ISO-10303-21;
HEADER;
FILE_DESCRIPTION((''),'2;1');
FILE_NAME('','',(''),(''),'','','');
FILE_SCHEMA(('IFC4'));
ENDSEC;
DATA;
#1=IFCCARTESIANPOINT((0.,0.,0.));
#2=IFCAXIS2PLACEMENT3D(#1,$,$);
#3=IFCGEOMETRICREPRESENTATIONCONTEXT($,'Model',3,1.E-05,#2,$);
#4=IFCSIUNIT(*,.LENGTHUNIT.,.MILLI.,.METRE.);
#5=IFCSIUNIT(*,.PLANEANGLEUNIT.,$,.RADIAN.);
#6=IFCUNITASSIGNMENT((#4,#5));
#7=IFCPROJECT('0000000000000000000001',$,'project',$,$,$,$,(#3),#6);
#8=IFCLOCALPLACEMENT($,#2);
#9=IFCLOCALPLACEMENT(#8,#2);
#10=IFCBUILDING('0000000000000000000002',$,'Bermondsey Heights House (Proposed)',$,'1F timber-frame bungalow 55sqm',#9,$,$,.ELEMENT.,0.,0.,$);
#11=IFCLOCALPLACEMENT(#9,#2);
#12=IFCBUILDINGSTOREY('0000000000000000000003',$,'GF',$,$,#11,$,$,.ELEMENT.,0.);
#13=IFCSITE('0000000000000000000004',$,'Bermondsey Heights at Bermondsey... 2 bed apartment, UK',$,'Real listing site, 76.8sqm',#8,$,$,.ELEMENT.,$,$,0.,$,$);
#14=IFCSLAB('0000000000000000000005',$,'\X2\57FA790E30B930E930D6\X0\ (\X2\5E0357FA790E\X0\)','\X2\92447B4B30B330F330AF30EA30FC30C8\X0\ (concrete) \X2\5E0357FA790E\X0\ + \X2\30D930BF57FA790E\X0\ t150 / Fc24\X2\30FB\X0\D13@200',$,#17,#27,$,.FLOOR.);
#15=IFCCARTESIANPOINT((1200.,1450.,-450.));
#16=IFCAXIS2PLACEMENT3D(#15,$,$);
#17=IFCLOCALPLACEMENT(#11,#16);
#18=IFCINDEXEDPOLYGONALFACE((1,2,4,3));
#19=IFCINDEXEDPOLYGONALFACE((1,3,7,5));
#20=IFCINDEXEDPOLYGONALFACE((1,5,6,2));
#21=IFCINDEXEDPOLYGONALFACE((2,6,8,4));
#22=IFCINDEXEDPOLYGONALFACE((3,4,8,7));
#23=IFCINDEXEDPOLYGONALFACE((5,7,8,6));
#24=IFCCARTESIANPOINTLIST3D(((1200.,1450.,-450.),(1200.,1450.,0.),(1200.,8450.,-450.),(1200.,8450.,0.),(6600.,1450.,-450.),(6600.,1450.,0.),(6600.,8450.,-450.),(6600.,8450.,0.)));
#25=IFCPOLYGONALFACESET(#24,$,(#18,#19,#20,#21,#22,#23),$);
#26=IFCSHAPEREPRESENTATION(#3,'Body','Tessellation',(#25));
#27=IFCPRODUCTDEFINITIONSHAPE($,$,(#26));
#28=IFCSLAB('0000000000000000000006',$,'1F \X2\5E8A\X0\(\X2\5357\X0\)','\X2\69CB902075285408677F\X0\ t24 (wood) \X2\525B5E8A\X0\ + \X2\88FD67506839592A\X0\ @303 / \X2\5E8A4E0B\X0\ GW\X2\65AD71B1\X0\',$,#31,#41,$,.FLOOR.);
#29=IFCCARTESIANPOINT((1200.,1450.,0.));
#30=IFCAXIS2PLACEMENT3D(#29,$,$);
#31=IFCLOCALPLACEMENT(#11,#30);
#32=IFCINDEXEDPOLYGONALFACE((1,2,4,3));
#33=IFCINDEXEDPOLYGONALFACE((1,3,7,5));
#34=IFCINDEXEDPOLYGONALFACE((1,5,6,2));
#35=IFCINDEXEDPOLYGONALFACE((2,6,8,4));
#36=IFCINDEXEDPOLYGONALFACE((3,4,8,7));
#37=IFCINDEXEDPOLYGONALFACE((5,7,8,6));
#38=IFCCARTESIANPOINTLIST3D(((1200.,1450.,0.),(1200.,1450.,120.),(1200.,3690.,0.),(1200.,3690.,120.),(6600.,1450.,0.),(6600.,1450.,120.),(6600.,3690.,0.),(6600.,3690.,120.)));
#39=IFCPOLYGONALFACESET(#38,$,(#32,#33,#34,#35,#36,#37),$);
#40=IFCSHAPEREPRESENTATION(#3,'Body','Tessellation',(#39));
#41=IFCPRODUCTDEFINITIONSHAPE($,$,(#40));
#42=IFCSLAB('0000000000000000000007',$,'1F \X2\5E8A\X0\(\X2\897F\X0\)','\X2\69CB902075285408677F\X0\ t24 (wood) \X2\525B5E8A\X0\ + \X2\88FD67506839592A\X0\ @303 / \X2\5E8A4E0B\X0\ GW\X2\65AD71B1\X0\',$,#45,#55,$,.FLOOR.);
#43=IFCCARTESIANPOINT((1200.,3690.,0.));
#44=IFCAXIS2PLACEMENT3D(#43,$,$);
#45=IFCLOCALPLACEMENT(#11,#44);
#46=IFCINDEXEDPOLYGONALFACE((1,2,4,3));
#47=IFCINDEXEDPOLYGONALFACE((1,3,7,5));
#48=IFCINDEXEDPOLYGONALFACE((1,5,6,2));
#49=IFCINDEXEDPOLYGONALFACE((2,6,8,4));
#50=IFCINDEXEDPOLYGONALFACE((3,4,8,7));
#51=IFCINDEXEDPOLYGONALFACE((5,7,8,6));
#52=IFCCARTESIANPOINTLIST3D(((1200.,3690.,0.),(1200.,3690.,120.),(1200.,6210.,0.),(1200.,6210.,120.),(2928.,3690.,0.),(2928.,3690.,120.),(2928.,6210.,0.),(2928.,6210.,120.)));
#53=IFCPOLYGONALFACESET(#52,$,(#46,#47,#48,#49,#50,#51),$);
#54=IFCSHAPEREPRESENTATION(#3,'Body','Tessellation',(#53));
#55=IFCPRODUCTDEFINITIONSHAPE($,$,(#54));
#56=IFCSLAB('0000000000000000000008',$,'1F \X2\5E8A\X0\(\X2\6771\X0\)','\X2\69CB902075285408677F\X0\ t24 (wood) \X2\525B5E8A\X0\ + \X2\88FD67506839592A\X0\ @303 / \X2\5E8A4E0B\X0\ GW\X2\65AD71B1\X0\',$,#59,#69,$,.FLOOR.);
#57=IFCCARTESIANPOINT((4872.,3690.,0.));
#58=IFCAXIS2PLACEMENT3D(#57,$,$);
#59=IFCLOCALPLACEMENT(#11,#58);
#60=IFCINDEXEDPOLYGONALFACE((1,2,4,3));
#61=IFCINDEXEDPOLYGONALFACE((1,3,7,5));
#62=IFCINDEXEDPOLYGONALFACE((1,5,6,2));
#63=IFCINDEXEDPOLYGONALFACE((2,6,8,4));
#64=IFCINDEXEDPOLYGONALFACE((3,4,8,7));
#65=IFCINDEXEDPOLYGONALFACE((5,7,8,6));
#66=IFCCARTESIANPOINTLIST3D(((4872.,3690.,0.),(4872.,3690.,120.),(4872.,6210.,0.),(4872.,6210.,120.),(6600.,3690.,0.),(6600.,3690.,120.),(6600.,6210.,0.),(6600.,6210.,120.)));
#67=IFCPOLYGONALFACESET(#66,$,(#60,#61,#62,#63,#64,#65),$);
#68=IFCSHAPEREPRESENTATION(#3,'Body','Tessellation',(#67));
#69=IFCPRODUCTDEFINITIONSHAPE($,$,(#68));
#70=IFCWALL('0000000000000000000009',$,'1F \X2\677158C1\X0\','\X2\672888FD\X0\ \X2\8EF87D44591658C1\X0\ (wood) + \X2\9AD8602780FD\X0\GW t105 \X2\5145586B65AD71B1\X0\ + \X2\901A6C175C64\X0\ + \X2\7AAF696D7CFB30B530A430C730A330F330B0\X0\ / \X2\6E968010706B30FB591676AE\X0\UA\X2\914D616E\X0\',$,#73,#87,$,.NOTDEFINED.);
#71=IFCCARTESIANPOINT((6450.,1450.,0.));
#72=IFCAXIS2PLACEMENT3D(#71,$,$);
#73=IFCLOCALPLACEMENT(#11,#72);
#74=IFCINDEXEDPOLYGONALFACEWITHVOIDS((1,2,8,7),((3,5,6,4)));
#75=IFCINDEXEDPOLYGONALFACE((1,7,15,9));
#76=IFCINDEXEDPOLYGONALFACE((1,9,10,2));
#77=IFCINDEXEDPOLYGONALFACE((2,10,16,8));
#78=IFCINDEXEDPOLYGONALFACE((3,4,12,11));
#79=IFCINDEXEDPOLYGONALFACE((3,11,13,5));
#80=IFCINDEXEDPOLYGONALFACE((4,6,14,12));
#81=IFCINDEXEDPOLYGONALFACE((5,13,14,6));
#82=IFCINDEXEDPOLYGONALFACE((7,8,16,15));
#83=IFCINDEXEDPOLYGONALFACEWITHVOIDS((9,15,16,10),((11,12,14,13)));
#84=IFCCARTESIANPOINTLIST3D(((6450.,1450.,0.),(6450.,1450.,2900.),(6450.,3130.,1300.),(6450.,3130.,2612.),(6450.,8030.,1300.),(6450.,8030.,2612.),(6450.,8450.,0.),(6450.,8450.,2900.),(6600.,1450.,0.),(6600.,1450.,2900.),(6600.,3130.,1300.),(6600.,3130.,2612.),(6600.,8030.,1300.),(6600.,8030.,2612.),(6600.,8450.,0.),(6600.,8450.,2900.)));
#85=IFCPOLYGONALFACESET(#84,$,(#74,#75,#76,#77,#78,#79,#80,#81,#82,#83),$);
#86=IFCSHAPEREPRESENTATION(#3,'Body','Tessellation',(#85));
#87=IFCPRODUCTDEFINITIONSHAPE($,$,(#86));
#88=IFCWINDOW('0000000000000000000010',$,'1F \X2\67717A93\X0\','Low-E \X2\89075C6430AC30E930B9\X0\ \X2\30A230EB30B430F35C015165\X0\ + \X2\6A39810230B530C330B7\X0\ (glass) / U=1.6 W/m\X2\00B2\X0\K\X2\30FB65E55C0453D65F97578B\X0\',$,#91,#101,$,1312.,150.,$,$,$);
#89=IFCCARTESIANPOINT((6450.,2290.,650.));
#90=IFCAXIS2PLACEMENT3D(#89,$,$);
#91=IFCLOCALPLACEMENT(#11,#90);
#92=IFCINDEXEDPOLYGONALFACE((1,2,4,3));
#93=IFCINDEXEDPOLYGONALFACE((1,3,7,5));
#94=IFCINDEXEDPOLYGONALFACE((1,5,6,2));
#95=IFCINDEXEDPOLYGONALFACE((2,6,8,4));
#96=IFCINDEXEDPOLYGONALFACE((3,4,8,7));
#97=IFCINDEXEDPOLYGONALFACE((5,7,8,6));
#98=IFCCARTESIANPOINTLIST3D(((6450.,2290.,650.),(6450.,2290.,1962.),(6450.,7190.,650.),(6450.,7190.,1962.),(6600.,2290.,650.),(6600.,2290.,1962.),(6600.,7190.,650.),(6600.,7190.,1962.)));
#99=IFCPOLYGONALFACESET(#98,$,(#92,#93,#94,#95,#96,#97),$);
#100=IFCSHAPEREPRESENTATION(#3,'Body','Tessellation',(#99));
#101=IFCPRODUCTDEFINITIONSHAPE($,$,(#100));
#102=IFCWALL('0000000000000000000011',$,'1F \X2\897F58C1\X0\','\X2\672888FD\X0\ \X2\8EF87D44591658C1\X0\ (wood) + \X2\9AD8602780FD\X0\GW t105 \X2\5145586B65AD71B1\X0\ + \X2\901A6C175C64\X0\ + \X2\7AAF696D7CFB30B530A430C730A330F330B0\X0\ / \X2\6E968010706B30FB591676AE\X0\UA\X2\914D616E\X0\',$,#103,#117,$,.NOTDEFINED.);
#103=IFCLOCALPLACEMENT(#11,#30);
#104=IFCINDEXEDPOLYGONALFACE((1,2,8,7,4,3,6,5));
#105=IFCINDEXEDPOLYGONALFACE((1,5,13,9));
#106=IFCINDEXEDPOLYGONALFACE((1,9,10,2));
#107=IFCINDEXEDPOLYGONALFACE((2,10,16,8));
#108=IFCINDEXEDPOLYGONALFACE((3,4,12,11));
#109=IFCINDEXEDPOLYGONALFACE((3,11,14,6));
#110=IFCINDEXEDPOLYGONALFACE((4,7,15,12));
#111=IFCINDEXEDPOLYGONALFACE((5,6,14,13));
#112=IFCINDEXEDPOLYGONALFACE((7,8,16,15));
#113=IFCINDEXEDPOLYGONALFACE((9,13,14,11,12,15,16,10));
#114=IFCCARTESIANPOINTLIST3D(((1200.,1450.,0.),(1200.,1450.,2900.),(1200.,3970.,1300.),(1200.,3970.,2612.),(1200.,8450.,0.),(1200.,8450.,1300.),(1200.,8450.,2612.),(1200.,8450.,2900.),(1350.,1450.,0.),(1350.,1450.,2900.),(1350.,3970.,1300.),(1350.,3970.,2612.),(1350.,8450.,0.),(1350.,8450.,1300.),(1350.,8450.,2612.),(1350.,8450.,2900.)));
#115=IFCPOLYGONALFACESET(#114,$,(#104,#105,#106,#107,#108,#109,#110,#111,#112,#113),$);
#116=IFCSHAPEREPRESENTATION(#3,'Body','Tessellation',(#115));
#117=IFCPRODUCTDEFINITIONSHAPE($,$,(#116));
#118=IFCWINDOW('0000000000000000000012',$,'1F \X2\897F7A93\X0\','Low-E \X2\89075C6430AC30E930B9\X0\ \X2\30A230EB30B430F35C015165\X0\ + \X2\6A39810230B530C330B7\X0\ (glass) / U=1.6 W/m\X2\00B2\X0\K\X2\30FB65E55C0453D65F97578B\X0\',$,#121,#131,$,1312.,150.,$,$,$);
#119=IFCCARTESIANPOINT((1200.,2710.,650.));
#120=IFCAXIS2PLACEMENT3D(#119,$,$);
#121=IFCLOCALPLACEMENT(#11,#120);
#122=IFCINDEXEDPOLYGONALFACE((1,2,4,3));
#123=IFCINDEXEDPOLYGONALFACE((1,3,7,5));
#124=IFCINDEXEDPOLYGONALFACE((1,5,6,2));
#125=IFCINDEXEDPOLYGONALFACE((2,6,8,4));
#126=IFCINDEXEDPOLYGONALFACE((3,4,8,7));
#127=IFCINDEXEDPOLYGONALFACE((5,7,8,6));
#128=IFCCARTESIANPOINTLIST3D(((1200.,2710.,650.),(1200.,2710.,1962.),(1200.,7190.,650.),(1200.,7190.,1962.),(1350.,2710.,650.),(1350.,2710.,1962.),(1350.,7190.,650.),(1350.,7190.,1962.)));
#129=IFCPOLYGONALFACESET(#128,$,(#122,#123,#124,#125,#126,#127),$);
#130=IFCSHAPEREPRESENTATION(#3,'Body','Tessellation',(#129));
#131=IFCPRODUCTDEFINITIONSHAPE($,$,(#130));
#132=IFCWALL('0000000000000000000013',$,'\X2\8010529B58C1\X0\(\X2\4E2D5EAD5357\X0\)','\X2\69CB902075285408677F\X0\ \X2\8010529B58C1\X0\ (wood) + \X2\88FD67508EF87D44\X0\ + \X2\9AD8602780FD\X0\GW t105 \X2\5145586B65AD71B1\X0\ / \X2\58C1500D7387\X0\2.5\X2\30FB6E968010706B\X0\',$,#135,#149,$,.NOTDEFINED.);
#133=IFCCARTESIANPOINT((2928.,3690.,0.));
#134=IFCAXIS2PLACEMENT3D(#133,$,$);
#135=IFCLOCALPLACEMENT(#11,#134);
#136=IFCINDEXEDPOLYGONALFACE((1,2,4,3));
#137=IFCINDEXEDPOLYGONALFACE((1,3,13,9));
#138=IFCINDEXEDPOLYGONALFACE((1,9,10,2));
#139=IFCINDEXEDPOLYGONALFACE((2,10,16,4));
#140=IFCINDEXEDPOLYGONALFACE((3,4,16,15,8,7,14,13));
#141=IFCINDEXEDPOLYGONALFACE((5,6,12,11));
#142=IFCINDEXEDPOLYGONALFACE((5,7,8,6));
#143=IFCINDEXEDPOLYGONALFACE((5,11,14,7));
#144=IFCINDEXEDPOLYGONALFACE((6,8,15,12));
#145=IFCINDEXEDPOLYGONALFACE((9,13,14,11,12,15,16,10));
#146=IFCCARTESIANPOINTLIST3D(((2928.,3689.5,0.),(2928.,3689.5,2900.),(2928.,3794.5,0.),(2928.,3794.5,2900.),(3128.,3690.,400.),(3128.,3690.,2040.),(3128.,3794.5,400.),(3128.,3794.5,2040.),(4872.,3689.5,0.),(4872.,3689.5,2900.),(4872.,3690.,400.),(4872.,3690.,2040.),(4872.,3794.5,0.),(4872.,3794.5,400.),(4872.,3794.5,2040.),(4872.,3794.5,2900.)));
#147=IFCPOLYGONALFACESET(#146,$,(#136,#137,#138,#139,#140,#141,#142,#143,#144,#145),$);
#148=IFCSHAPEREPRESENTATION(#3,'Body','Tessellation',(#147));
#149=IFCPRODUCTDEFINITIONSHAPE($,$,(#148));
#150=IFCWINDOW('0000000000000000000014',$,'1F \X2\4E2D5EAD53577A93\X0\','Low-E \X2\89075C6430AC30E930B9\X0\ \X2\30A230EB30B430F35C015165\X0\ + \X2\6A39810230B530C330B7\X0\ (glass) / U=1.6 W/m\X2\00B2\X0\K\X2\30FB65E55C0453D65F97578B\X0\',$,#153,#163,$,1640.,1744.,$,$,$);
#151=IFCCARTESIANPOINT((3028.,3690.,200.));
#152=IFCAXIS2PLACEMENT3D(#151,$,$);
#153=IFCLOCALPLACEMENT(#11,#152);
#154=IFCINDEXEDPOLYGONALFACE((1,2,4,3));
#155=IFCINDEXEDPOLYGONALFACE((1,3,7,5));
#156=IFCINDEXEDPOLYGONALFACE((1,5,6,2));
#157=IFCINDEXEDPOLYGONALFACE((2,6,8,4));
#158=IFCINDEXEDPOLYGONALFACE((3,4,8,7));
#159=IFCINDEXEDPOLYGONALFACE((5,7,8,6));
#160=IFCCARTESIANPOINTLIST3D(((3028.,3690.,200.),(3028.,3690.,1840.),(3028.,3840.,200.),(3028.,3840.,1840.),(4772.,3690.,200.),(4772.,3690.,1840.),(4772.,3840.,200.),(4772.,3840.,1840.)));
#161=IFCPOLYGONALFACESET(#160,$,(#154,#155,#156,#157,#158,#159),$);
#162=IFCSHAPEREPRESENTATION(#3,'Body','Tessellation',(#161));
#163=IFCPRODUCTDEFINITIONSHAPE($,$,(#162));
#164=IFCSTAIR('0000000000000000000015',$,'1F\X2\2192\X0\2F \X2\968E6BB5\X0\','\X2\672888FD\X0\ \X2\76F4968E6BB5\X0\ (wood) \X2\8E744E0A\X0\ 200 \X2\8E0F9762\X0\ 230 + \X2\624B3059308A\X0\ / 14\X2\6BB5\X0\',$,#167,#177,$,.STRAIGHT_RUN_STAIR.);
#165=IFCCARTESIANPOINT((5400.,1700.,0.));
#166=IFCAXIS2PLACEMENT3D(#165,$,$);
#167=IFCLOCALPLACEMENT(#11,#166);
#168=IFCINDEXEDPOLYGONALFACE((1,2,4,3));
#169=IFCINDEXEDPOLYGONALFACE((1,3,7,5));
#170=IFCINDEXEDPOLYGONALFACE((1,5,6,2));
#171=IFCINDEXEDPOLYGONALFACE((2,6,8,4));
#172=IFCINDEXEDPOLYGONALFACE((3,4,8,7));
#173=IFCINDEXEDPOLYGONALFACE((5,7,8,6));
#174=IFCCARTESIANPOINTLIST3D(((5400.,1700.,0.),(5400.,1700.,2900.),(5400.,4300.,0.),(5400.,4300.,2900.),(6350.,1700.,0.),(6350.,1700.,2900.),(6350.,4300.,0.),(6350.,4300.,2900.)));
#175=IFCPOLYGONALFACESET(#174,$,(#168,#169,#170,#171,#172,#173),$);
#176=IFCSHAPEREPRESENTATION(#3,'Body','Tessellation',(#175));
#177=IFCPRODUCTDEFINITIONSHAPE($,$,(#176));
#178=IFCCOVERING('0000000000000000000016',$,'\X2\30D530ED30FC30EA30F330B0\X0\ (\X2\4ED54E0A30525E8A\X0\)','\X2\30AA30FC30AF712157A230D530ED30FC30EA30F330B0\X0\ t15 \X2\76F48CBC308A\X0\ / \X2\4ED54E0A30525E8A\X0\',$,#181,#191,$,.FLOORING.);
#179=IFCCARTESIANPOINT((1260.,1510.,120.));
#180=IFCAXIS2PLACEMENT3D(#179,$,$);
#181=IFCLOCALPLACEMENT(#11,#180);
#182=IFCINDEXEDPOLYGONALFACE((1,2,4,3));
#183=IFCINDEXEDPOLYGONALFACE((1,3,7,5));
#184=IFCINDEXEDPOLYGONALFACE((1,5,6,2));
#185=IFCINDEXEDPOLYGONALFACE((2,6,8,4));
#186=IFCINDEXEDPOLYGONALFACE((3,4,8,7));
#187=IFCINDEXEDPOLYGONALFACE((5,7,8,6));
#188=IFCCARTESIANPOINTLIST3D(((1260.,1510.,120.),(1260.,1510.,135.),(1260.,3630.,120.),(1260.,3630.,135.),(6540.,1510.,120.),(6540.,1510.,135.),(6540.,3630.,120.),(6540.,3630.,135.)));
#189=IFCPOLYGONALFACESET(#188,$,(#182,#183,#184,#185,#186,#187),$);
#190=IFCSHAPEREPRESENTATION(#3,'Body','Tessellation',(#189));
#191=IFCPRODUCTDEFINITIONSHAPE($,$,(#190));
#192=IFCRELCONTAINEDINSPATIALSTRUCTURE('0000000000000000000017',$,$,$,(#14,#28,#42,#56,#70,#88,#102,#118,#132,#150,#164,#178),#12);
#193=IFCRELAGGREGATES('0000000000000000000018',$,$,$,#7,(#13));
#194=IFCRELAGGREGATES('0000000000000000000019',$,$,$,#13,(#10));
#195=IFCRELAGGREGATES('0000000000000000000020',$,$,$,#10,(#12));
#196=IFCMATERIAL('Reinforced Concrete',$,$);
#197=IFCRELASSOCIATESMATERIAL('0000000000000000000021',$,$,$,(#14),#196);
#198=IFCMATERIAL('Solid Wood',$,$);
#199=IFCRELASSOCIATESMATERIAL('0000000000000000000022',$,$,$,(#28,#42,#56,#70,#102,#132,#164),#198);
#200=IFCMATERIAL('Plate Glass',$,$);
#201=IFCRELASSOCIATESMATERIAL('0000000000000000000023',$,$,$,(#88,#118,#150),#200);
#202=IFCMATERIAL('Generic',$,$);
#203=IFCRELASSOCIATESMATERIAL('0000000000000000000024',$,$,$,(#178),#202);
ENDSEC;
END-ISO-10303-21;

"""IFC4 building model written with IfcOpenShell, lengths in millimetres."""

from ifc_helpers import new_model, si_unit, frame, frame_2d, origin, place, context, project, spatial, rectangle, extrude, material, element, fill, save


model = new_model("IFC4")

# Units and contexts
model_context = context("Model", 3, precision=1e-05, world=origin())
ifc_project = project(units=[si_unit("LENGTHUNIT", "METRE", prefix="MILLI"), si_unit("PLANEANGLEUNIT", "RADIAN")], contexts=[model_context])

# Site, building, storey
site_placement = place(None, origin())
site = spatial("IfcSite", under=ifc_project, at=site_placement, Name="Bermondsey Heights at Bermondsey... 2 bed apartment, UK", ObjectType="Real listing site, 76.8sqm", CompositionType="ELEMENT", RefElevation=0.0)
building_placement = place(site_placement, origin())
building = spatial("IfcBuilding", under=site, at=building_placement, Name="Bermondsey Heights House (Proposed)", ObjectType="1F timber-frame bungalow 55sqm", CompositionType="ELEMENT", ElevationOfRefHeight=0.0, ElevationOfTerrain=0.0)
storey_placement = place(building_placement, origin())
storey = spatial("IfcBuildingStorey", under=building, at=storey_placement, Name="GF", CompositionType="ELEMENT", Elevation=0.0)

# Slabs
ifc_material_1 = material(Name="Reinforced Concrete")
slab_1_placement = place(storey_placement, frame((1200.0, 1450.0, -450.0)))
element("IfcSlab", 1, at=slab_1_placement, inside=storey, material=ifc_material_1, Name="基礎スラブ (布基礎)", Description="鉄筋コンクリート (concrete) 布基礎 + ベタ基礎 t150 / Fc24・D13@200", PredefinedType="FLOOR", context=model_context, shape_type="SweptSolid", body=[
    extrude(rectangle(XDim=5400.0, YDim=7000.0, at=frame_2d((2700.0, 3500.0))), frame((1200.0, 1450.0, -450.0)), (0.0, 0.0, 1.0), 450.0),
])
ifc_material_2 = material(Name="Solid Wood")
slab_2_placement = place(storey_placement, frame((1200.0, 1450.0, 0.0)))
element("IfcSlab", 2, at=slab_2_placement, inside=storey, material=ifc_material_2, Name="1F 床(南)", Description="構造用合板 t24 (wood) 剛床 + 製材根太 @303 / 床下 GW断熱", PredefinedType="FLOOR", context=model_context, shape_type="SweptSolid", body=[
    extrude(rectangle(XDim=5400.0, YDim=2240.0, at=frame_2d((2700.0, 1120.0))), frame((1200.0, 1450.0, 0.0)), (0.0, 0.0, 1.0), 120.0),
])
slab_3_placement = place(storey_placement, frame((1200.0, 3690.0, 0.0)))
element("IfcSlab", 3, at=slab_3_placement, inside=storey, material=ifc_material_2, Name="1F 床(西)", Description="構造用合板 t24 (wood) 剛床 + 製材根太 @303 / 床下 GW断熱", PredefinedType="FLOOR", context=model_context, shape_type="SweptSolid", body=[
    extrude(rectangle(XDim=1728.0, YDim=2520.0, at=frame_2d((864.0, 1260.0))), frame((1200.0, 3690.0, 0.0)), (0.0, 0.0, 1.0), 120.0),
])
slab_4_placement = place(storey_placement, frame((4872.0, 3690.0, 0.0)))
element("IfcSlab", 4, at=slab_4_placement, inside=storey, material=ifc_material_2, Name="1F 床(東)", Description="構造用合板 t24 (wood) 剛床 + 製材根太 @303 / 床下 GW断熱", PredefinedType="FLOOR", context=model_context, shape_type="SweptSolid", body=[
    extrude(rectangle(XDim=1728.0, YDim=2520.0, at=frame_2d((864.0, 1260.0))), frame((4872.0, 3690.0, 0.0)), (0.0, 0.0, 1.0), 120.0),
])

# Shared definitions
ifc_material_3 = material(Name="Plate Glass")

# Walls, openings, windows
wall_1_placement = place(storey_placement, frame((6450.0, 1450.0, 0.0)))
wall_1 = element("IfcWall", 5, at=wall_1_placement, inside=storey, material=ifc_material_2, Name="1F 東壁", Description="木製 軸組外壁 (wood) + 高性能GW t105 充填断熱 + 通気層 + 窯業系サイディング / 準耐火・外皮UA配慮", PredefinedType="NOTDEFINED", context=model_context, shape_type="SweptSolid", body=[
    extrude(rectangle(XDim=150.0, YDim=7000.0, at=frame_2d((75.0, 3500.0))), frame((6450.0, 1450.0, 0.0)), (0.0, 0.0, 1.0), 2900.0),
])
opening_1_placement = place(storey_placement, frame((6450.0, 2290.0, 650.0)))
opening_1 = element("IfcOpeningElement", 6, at=opening_1_placement, cuts=wall_1, PredefinedType="NOTDEFINED", context=model_context, shape_type="SweptSolid", body=[
    extrude(rectangle(XDim=150.0, YDim=4900.0, at=frame_2d((75.0, 2450.0))), frame((6450.0, 2290.0, 650.0)), (0.0, 0.0, 1.0), 1312.0),
])
window_1_placement = place(storey_placement, frame((6450.0, 2290.0, 650.0)))
window_1 = element("IfcWindow", 7, at=window_1_placement, inside=storey, material=ifc_material_3, Name="1F 東窓", Description="Low-E 複層ガラス アルゴン封入 + 樹脂サッシ (glass) / U=1.6 W/m²K・日射取得型", OverallHeight=1312.0, OverallWidth=150.0, context=model_context, shape_type="SweptSolid", body=[
    extrude(rectangle(XDim=150.0, YDim=4900.0, at=frame_2d((75.0, 2450.0))), frame((6450.0, 2290.0, 650.0)), (0.0, 0.0, 1.0), 1312.0),
])
fill(opening_1, window_1)
wall_2_placement = place(storey_placement, frame((1200.0, 1450.0, 0.0)))
wall_2 = element("IfcWall", 8, at=wall_2_placement, inside=storey, material=ifc_material_2, Name="1F 西壁", Description="木製 軸組外壁 (wood) + 高性能GW t105 充填断熱 + 通気層 + 窯業系サイディング / 準耐火・外皮UA配慮", PredefinedType="NOTDEFINED", context=model_context, shape_type="SweptSolid", body=[
    extrude(rectangle(XDim=150.0, YDim=7000.0, at=frame_2d((75.0, 3500.0))), frame((1200.0, 1450.0, 0.0)), (0.0, 0.0, 1.0), 2900.0),
])
opening_2_placement = place(storey_placement, frame((1200.0, 2710.0, 650.0)))
opening_2 = element("IfcOpeningElement", 9, at=opening_2_placement, cuts=wall_2, PredefinedType="NOTDEFINED", context=model_context, shape_type="SweptSolid", body=[
    extrude(rectangle(XDim=150.0, YDim=4480.0, at=frame_2d((75.0, 2240.0))), frame((1200.0, 2710.0, 650.0)), (0.0, 0.0, 1.0), 1312.0),
])
window_2_placement = place(storey_placement, frame((1200.0, 2710.0, 650.0)))
window_2 = element("IfcWindow", 10, at=window_2_placement, inside=storey, material=ifc_material_3, Name="1F 西窓", Description="Low-E 複層ガラス アルゴン封入 + 樹脂サッシ (glass) / U=1.6 W/m²K・日射取得型", OverallHeight=1312.0, OverallWidth=150.0, context=model_context, shape_type="SweptSolid", body=[
    extrude(rectangle(XDim=150.0, YDim=4480.0, at=frame_2d((75.0, 2240.0))), frame((1200.0, 2710.0, 650.0)), (0.0, 0.0, 1.0), 1312.0),
])
fill(opening_2, window_2)
wall_3_placement = place(storey_placement, frame((2928.0, 3690.0, 0.0)))
wall_3 = element("IfcWall", 11, at=wall_3_placement, inside=storey, material=ifc_material_2, Name="耐力壁(中庭南)", Description="構造用合板 耐力壁 (wood) + 製材軸組 + 高性能GW t105 充填断熱 / 壁倍率2.5・準耐火", PredefinedType="NOTDEFINED", context=model_context, shape_type="SweptSolid", body=[
    extrude(rectangle(XDim=1944.0, YDim=105.0, at=frame_2d((972.0, 52.0))), frame((2928.0, 3690.0, 0.0)), (0.0, 0.0, 1.0), 2900.0),
])
opening_3_placement = place(storey_placement, frame((3028.0, 3690.0, 200.0)))
opening_3 = element("IfcOpeningElement", 12, at=opening_3_placement, cuts=wall_3, PredefinedType="NOTDEFINED", context=model_context, shape_type="SweptSolid", body=[
    extrude(rectangle(XDim=1744.0, YDim=150.0, at=frame_2d((872.0, 75.0))), frame((3028.0, 3690.0, 200.0)), (0.0, 0.0, 1.0), 1640.0),
])
window_3_placement = place(storey_placement, frame((3028.0, 3690.0, 200.0)))
window_3 = element("IfcWindow", 13, at=window_3_placement, inside=storey, material=ifc_material_3, Name="1F 中庭南窓", Description="Low-E 複層ガラス アルゴン封入 + 樹脂サッシ (glass) / U=1.6 W/m²K・日射取得型", OverallHeight=1640.0, OverallWidth=1744.0, context=model_context, shape_type="SweptSolid", body=[
    extrude(rectangle(XDim=1744.0, YDim=150.0, at=frame_2d((872.0, 75.0))), frame((3028.0, 3690.0, 200.0)), (0.0, 0.0, 1.0), 1640.0),
])
fill(opening_3, window_3)

# Stair
stair_placement = place(storey_placement, frame((5400.0, 1700.0, 0.0)))
element("IfcStair", 14, at=stair_placement, inside=storey, material=ifc_material_2, Name="1F→2F 階段", Description="木製 直階段 (wood) 蹴上 200 踏面 230 + 手すり / 14段", PredefinedType="STRAIGHT_RUN_STAIR", context=model_context, shape_type="SweptSolid", body=[
    extrude(rectangle(XDim=950.0, YDim=2600.0, at=frame_2d((475.0, 1300.0))), frame((5400.0, 1700.0, 0.0)), (0.0, 0.0, 1.0), 2900.0),
])

# Covering
ifc_material_4 = material(Name="Generic")
covering_placement = place(storey_placement, frame((1260.0, 1510.0, 120.0)))
element("IfcCovering", 15, at=covering_placement, inside=storey, material=ifc_material_4, Name="フローリング (仕上げ床)", Description="オーク無垢フローリング t15 直貼り / 仕上げ床", PredefinedType="FLOORING", context=model_context, shape_type="SweptSolid", body=[
    extrude(rectangle(XDim=5280.0, YDim=2120.0, at=frame_2d((2640.0, 1060.0))), frame((1260.0, 1510.0, 120.0)), (0.0, 0.0, 1.0), 15.0),
])

save(model, "model.ifc")
